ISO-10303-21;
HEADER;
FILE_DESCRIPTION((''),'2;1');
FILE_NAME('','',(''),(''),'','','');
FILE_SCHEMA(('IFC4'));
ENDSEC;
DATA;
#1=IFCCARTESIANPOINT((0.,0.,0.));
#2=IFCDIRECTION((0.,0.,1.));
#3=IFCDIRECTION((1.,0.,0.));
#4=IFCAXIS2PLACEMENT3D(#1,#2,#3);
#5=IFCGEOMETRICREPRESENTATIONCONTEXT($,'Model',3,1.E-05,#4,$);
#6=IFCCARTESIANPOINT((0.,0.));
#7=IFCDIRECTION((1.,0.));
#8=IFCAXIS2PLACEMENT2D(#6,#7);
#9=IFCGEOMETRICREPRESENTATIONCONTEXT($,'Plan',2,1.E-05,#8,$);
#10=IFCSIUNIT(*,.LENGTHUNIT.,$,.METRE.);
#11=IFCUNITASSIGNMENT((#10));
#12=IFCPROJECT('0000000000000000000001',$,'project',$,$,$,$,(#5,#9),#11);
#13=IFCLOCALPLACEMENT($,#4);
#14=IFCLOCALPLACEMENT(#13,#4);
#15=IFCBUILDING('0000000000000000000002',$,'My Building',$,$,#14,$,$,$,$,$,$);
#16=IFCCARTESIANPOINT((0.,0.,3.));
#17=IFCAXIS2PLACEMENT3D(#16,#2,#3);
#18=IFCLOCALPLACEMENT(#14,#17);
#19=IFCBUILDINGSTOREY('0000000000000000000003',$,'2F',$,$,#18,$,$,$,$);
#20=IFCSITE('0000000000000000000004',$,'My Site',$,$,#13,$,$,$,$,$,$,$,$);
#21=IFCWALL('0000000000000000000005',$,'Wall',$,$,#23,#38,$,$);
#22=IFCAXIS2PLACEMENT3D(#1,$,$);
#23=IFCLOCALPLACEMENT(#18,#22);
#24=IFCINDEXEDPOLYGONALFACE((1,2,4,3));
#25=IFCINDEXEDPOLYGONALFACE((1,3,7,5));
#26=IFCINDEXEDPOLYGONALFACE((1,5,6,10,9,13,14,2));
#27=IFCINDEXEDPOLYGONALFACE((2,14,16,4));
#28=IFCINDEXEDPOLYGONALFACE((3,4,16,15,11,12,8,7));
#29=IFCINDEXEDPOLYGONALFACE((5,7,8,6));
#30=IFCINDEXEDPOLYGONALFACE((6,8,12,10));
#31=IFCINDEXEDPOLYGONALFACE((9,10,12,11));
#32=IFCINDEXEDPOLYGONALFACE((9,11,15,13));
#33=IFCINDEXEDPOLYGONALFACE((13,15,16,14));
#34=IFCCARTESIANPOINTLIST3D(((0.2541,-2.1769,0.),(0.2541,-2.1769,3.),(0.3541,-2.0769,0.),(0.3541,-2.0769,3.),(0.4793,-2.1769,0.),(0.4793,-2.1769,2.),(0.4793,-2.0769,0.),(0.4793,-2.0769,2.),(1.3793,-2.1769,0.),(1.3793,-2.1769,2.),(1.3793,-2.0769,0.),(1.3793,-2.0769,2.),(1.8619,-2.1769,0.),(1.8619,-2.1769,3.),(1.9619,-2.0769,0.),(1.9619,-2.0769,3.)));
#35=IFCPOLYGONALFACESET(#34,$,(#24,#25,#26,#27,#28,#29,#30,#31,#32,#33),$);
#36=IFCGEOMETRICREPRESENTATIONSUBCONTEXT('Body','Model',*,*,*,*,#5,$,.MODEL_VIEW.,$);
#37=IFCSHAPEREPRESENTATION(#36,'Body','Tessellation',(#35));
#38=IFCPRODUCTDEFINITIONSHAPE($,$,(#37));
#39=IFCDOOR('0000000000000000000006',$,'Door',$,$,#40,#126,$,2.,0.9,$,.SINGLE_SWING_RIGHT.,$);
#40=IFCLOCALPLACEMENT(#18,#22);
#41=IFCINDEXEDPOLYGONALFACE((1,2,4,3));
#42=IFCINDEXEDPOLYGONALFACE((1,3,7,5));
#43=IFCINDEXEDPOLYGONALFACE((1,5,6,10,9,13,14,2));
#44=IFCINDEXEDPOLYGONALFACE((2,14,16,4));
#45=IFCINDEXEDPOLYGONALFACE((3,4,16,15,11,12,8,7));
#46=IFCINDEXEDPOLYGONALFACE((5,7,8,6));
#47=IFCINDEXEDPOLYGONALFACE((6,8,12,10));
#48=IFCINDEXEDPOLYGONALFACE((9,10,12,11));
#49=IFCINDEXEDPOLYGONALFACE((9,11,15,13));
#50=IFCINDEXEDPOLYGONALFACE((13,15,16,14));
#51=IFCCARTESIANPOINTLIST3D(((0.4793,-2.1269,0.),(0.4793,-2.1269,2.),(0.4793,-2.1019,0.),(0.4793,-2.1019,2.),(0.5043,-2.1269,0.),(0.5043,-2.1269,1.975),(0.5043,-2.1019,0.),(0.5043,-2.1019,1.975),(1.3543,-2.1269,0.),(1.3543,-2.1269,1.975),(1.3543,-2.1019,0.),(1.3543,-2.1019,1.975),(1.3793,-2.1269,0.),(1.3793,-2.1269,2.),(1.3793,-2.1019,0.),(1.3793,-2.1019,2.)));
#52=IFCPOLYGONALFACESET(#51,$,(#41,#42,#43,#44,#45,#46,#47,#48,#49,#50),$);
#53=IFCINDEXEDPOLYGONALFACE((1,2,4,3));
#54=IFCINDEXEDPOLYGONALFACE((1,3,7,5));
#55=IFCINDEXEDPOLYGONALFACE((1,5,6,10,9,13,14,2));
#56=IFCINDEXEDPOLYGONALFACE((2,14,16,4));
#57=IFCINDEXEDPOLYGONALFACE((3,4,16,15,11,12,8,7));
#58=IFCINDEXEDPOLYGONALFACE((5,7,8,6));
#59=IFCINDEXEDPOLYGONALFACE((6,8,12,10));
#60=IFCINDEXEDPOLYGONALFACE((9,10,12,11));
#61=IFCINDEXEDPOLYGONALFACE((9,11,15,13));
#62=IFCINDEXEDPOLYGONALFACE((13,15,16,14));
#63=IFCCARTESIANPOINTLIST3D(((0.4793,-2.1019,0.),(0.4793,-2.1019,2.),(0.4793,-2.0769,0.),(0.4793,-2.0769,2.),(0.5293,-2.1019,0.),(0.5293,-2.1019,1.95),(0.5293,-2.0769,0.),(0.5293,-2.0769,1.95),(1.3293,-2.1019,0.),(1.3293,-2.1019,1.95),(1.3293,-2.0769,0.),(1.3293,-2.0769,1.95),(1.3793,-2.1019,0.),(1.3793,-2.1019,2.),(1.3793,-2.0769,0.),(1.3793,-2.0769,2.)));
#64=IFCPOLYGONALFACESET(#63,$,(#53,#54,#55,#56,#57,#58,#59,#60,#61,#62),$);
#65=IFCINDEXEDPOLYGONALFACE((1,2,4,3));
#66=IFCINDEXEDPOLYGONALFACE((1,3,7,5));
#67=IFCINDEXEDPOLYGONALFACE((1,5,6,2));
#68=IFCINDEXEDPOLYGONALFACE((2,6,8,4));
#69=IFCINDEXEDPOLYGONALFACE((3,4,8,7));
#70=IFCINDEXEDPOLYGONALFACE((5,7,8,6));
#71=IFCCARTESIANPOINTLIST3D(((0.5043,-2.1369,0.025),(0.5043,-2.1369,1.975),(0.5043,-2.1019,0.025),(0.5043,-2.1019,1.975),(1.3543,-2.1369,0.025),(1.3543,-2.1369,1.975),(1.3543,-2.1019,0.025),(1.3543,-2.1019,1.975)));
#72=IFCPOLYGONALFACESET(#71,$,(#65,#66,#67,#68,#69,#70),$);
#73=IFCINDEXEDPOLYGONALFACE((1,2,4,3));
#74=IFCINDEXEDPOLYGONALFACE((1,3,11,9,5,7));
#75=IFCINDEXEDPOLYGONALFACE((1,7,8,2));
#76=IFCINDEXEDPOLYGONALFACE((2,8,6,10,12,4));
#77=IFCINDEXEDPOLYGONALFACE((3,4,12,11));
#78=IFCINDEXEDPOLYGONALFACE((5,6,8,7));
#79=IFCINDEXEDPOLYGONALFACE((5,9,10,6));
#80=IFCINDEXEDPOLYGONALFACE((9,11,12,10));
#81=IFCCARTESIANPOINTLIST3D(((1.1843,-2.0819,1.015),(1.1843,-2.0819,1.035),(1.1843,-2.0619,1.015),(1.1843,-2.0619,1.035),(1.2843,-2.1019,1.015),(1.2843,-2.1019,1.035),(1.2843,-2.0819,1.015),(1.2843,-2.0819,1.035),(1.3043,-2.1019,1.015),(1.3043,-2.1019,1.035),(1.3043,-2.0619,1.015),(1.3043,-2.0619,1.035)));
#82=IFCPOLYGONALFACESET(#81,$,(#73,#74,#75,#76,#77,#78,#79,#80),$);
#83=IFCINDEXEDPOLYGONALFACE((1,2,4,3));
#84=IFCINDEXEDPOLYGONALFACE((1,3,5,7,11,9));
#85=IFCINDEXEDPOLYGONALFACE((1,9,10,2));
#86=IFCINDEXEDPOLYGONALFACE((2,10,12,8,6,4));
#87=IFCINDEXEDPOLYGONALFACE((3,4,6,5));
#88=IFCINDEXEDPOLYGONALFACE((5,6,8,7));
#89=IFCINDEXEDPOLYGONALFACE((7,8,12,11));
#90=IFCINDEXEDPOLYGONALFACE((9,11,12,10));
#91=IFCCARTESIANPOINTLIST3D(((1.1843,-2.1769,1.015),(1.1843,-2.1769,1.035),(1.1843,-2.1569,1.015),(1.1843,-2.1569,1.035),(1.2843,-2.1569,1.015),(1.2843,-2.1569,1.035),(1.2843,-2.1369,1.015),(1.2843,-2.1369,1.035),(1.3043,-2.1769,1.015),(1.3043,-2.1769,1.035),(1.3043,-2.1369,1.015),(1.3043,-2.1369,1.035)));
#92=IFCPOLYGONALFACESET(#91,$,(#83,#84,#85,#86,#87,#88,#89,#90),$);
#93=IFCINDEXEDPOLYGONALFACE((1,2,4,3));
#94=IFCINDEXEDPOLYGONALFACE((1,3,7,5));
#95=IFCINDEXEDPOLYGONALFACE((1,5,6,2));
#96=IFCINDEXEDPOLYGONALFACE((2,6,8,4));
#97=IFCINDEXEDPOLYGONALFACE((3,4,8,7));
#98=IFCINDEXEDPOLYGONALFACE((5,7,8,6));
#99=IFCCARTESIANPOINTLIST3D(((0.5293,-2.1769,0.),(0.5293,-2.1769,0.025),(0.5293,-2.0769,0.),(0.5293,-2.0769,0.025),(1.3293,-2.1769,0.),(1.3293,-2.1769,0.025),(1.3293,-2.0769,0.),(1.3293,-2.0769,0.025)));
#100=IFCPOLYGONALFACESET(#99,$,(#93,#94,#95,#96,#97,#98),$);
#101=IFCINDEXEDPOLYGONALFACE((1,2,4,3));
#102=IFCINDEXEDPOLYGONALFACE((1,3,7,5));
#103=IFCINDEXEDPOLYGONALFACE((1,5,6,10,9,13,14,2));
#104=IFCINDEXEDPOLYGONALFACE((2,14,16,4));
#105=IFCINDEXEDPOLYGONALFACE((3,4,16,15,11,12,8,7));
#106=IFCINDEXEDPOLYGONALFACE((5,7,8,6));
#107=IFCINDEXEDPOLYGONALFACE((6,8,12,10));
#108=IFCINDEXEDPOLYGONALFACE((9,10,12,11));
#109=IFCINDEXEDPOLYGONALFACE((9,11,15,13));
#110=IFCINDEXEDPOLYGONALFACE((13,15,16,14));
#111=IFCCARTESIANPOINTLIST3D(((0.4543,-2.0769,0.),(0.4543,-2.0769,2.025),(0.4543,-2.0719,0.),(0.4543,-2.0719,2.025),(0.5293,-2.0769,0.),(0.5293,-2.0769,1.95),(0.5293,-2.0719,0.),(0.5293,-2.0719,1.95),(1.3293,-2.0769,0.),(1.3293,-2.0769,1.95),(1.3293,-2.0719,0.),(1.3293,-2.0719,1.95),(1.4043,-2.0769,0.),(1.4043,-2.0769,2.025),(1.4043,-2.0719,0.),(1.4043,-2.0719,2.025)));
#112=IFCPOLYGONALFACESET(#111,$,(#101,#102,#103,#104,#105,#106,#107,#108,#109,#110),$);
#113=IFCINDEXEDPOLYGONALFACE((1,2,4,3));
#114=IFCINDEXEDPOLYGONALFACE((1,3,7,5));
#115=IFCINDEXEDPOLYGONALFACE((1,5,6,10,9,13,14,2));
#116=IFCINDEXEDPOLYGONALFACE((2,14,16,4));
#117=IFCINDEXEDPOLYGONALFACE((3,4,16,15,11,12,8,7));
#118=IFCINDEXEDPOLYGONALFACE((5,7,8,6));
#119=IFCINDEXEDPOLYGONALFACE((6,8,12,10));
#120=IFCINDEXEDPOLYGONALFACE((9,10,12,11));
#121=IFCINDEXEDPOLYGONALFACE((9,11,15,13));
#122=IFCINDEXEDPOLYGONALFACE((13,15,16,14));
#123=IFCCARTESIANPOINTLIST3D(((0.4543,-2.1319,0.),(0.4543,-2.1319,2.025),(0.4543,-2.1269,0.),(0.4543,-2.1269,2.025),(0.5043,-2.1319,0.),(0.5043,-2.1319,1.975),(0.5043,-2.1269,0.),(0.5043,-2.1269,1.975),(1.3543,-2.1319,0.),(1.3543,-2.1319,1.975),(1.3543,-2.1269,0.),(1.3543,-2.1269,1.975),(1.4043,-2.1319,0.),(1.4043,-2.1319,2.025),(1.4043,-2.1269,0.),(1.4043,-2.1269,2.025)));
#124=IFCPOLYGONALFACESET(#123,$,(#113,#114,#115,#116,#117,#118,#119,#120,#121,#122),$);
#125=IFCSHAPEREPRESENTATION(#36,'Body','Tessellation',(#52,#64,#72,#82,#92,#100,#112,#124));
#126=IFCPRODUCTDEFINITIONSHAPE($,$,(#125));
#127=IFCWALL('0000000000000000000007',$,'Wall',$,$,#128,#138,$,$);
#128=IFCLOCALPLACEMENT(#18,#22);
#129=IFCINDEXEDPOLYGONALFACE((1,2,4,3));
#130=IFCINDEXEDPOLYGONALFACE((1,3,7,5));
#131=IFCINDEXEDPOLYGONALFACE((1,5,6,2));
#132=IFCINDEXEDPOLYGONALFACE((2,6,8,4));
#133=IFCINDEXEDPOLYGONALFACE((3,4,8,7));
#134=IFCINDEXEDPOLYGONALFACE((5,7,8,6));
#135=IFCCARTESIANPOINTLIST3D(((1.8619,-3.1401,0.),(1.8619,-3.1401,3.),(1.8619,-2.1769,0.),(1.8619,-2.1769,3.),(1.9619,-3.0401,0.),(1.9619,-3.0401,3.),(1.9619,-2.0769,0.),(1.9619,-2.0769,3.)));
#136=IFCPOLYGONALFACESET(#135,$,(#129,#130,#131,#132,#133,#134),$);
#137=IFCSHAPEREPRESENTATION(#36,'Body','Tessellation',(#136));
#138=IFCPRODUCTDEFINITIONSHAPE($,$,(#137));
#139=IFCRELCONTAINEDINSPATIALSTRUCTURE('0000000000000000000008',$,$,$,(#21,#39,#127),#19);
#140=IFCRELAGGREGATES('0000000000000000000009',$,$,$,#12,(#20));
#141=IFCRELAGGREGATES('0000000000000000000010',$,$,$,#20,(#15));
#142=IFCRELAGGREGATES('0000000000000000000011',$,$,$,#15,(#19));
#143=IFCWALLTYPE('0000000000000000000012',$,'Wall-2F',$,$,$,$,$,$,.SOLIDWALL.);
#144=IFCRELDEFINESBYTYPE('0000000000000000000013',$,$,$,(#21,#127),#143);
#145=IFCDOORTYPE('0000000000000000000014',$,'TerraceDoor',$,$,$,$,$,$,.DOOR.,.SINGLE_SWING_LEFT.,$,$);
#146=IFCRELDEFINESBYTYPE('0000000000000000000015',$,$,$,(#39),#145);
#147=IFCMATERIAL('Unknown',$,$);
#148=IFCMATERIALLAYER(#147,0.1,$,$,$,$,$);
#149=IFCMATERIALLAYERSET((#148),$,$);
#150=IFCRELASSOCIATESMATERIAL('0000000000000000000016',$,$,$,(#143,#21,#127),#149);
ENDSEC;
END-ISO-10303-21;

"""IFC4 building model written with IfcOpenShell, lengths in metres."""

from ifc_helpers import new_model, entity, si_unit, frame, origin_with_axes, origin_2d_with_axis, place, context, subcontext, project, spatial, line, indexed_curve, outline, extrude, shape, source, transform, mapped, material, layer, layer_set, layer_usage, type_object, type_shapes, element, fill, save


model = new_model("IFC4")

# Units and contexts
model_context = context("Model", 3, precision=1e-05, world=origin_with_axes())
plan_context = context("Plan", 2, precision=1e-05, world=origin_2d_with_axis())
body_context_1 = subcontext(model_context, "Body", "Model", "MODEL_VIEW")
body_context_2 = subcontext(plan_context, "Body", "Plan", "PLAN_VIEW")
ifc_project = project(units=[si_unit("LENGTHUNIT", "METRE")], contexts=[model_context, plan_context])

# Site, building, storey
site_placement = place(None, origin_with_axes())
site = spatial("IfcSite", under=ifc_project, at=site_placement, Name="My Site")
building_placement = place(site_placement, origin_with_axes())
building = spatial("IfcBuilding", under=site, at=building_placement, Name="My Building")
storey_placement = place(building_placement, frame((0.0, 0.0, 3.0), z_axis=(0.0, 0.0, 1.0), x_axis=(1.0, 0.0, 0.0)))
storey = spatial("IfcBuildingStorey", under=building, at=storey_placement, Name="2F")

# Shared definitions
ifc_material = material(Name="Unknown")

# Shared definitions
ifc_layer_1 = layer(ifc_material, 0.1)
ifc_layer_set_1 = layer_set([ifc_layer_1])
wall_type_1 = type_object("IfcWallType", Name="Wall-2F", PredefinedType="SOLIDWALL", material=ifc_layer_set_1)

# Wall, opening, door
ifc_layer_usage_1 = layer_usage(ifc_layer_set_1, "AXIS2", "POSITIVE", 0.0)
wall_1_placement = place(storey_placement, frame((0.2541, -2.1769, 0.0), z_axis=(0.0, 0.0, 1.0), x_axis=(1.0, 0.0, 0.0)))
wall_1 = element("IfcWall", 1, at=wall_1_placement, inside=storey, type_object=wall_type_1, material=ifc_layer_usage_1, Name="Wall", context=body_context_1, shape_type="SweptSolid", body=[
    extrude(outline(indexed_curve([(0.0, 0.0), (0.1, 0.1), (1.7078, 0.1), (1.6078, 0.0)], segments=[line(1, 2, 3, 4, 1)])), origin_with_axes(), (0.0, 0.0, 1.0), 3.0),
])
shared_shape_1 = source(origin_with_axes(), body_context_1, "Body", "SweptSolid", [
    extrude(outline(indexed_curve([(0.0, 0.0), (0.9, 0.0), (0.9, 2.0), (0.0, 2.0)], segments=[line(1, 2, 3, 4, 1)])), frame((0.0, -0.6, 0.0), z_axis=(0.0, -1.0, 0.0), x_axis=(1.0, 0.0, 0.0)), (0.0, 0.0, -1.0), 1.2),
])
opening_1_placement = place(wall_1_placement, frame((1.1252, 0.1, 0.0), z_axis=(0.0, 0.0, 1.0), x_axis=(-1.0, 0.0, 0.0)))
opening_1 = element("IfcOpeningElement", 2, at=opening_1_placement, cuts=wall_1, PredefinedType="OPENING", context=body_context_1, shape_type="MappedRepresentation", body=[
    mapped(shared_shape_1, transform((0.0, 0.0, 0.0), x_axis=(1.0, 0.0, 0.0), y_axis=(0.0, 1.0, 0.0), z_axis=(0.0, 0.0, 1.0), scale=1.0)),
])
door_type_1 = type_object("IfcDoorType", Name="TerraceDoor", OperationType="SINGLE_SWING_LEFT", PredefinedType="DOOR")
shared_shape_2 = source(origin_with_axes(), body_context_1, "Body", "SweptSolid", [
    extrude(outline(indexed_curve([(0.0, 0.0), (0.0, 2.0), (0.9, 2.0), (0.9, 0.0), (0.875, 0.0), (0.875, 1.975), (0.025, 1.975), (0.025, 0.0)], segments=[line(1, 2, 3, 4, 5, 6, 7, 8, 1)])), frame((0.0, 0.025, 0.0), z_axis=(0.0, -1.0, 0.0), x_axis=(1.0, 0.0, 0.0)), (0.0, 0.0, -1.0), 0.025),
    extrude(outline(indexed_curve([(0.0, 0.0), (0.0, 2.0), (0.9, 2.0), (0.9, 0.0), (0.85, 0.0), (0.85, 1.95), (0.05, 1.95), (0.05, 0.0)], segments=[line(1, 2, 3, 4, 5, 6, 7, 8, 1)])), frame((0.0, 0.0, 0.0), z_axis=(0.0, -1.0, 0.0), x_axis=(1.0, 0.0, 0.0)), (0.0, 0.0, -1.0), 0.025),
    extrude(outline(indexed_curve([(0.0, 0.0), (0.85, 0.0), (0.85, 0.035), (0.0, 0.035)], segments=[line(1, 2, 3, 4, 1)])), frame((0.025, 0.025, 0.025), z_axis=(0.0, 0.0, 1.0), x_axis=(1.0, 0.0, 0.0)), (0.0, 0.0, 1.0), 1.95),
    extrude(outline(indexed_curve([(0.0, 0.0), (0.0, -0.04), (0.12, -0.04), (0.12, -0.02), (0.02, -0.02), (0.02, 0.0)], segments=[line(1, 2, 3, 4, 5, 6, 1)])), frame((0.075, 0.025, 1.015), z_axis=(0.0, 0.0, 1.0), x_axis=(1.0, 0.0, 0.0)), (0.0, 0.0, 1.0), 0.02),
    extrude(outline(indexed_curve([(0.0, 0.0), (0.0, 0.04), (0.12, 0.04), (0.12, 0.02), (0.02, 0.02), (0.02, 0.0)], segments=[line(1, 2, 3, 4, 5, 6, 1)])), frame((0.075, 0.06, 1.015), z_axis=(0.0, 0.0, 1.0), x_axis=(1.0, 0.0, 0.0)), (0.0, 0.0, 1.0), 0.02),
    extrude(outline(indexed_curve([(0.0, 0.0), (0.8, 0.0), (0.8, 0.1), (0.0, 0.1)], segments=[line(1, 2, 3, 4, 1)])), frame((0.05, 0.0, 0.0), z_axis=(0.0, 0.0, 1.0), x_axis=(1.0, 0.0, 0.0)), (0.0, 0.0, 1.0), 0.025),
    extrude(outline(indexed_curve([(0.0, 0.0), (0.0, 2.025), (0.95, 2.025), (0.95, 0.0), (0.875, 0.0), (0.875, 1.95), (0.075, 1.95), (0.075, 0.0)], segments=[line(1, 2, 3, 4, 5, 6, 7, 8, 1)])), frame((-0.025, -0.005, 0.0), z_axis=(0.0, -1.0, 0.0), x_axis=(1.0, 0.0, 0.0)), (0.0, 0.0, -1.0), 0.005),
    extrude(outline(indexed_curve([(0.0, 0.0), (0.0, 2.025), (0.95, 2.025), (0.95, 0.0), (0.9, 0.0), (0.9, 1.975), (0.05, 1.975), (0.05, 0.0)], segments=[line(1, 2, 3, 4, 5, 6, 7, 8, 1)])), frame((-0.025, 0.05, 0.0), z_axis=(0.0, -1.0, 0.0), x_axis=(1.0, 0.0, 0.0)), (0.0, 0.0, -1.0), 0.005),
])
shared_shape_3 = source(origin_with_axes(), body_context_2, "Body", "Curve2D", [
    entity("IfcIndexedPolyCurve", entity("IfcCartesianPointList2D", [[0.0, 0.0], [0.0, 0.05], [0.025, 0.05], [0.025, 0.025], [0.05, 0.025], [0.05, 0.0]]), [entity("IfcLineIndex", [1, 2, 3, 4, 5, 6, 1])]),
    entity("IfcIndexedPolyCurve", entity("IfcCartesianPointList2D", [[0.9, 0.0], [0.9, 0.05], [0.875, 0.05], [0.875, 0.025], [0.85, 0.025], [0.85, 0.0]]), [entity("IfcLineIndex", [1, 2, 3, 4, 5, 6, 1])]),
    entity("IfcTrimmedCurve", entity("IfcEllipse", entity("IfcAxis2Placement2D", entity("IfcCartesianPoint", [0.84, 0.05]), entity("IfcDirection", [1.0, 0.0])), 0.815, 0.85), [entity("IfcCartesianPoint", [0.84, 0.9])], [entity("IfcCartesianPoint", [0.025, 0.05])], True, "CARTESIAN"),
    entity("IfcIndexedPolyCurve", entity("IfcCartesianPointList2D", [[0.875, 0.05], [0.84, 0.05], [0.84, 0.9], [0.875, 0.9]]), [entity("IfcLineIndex", [1, 2, 3, 4, 1])]),
])
type_shapes(door_type_1, [shared_shape_2, shared_shape_3])
door_1_placement = place(opening_1_placement, frame((0.0, 0.0, 0.0), z_axis=(0.0, 0.0, 1.0), x_axis=(1.0, 0.0, 0.0)))
door_1 = element("IfcDoor", 3, at=door_1_placement, inside=storey, type_object=door_type_1, Name="Door", OperationType="SINGLE_SWING_RIGHT", OverallHeight=2.0, OverallWidth=0.9, shapes=[
    shape(body_context_1, "Body", "MappedRepresentation", [mapped(shared_shape_2, transform((0.0, 0.0, 0.0), x_axis=(1.0, 0.0, 0.0), y_axis=(0.0, 1.0, 0.0), z_axis=(0.0, 0.0, 1.0), scale=1.0))]),
    shape(body_context_2, "Body", "MappedRepresentation", [mapped(shared_shape_3, transform((0.0, 0.0, 0.0), x_axis=(1.0, 0.0, 0.0), y_axis=(0.0, 1.0, 0.0), z_axis=(0.0, 0.0, 1.0), scale=1.0))]),
])
fill(opening_1, door_1)

# Wall
ifc_layer_usage_2 = layer_usage(ifc_layer_set_1, "AXIS2", "POSITIVE", 0.0)
wall_2_placement = place(storey_placement, frame((1.8619, -2.1769, 0.0), z_axis=(0.0, 0.0, 1.0), x_axis=(0.0, -1.0, 0.0)))
element("IfcWall", 4, at=wall_2_placement, inside=storey, type_object=wall_type_1, material=ifc_layer_usage_2, Name="Wall", context=body_context_1, shape_type="SweptSolid", body=[
    extrude(outline(indexed_curve([(0.0, 0.0), (-0.1, 0.1), (0.8632, 0.1), (0.9632, 0.0)], segments=[line(1, 2, 3, 4, 1)])), origin_with_axes(), (0.0, 0.0, 1.0), 3.0),
])

save(model, "model.ifc")
